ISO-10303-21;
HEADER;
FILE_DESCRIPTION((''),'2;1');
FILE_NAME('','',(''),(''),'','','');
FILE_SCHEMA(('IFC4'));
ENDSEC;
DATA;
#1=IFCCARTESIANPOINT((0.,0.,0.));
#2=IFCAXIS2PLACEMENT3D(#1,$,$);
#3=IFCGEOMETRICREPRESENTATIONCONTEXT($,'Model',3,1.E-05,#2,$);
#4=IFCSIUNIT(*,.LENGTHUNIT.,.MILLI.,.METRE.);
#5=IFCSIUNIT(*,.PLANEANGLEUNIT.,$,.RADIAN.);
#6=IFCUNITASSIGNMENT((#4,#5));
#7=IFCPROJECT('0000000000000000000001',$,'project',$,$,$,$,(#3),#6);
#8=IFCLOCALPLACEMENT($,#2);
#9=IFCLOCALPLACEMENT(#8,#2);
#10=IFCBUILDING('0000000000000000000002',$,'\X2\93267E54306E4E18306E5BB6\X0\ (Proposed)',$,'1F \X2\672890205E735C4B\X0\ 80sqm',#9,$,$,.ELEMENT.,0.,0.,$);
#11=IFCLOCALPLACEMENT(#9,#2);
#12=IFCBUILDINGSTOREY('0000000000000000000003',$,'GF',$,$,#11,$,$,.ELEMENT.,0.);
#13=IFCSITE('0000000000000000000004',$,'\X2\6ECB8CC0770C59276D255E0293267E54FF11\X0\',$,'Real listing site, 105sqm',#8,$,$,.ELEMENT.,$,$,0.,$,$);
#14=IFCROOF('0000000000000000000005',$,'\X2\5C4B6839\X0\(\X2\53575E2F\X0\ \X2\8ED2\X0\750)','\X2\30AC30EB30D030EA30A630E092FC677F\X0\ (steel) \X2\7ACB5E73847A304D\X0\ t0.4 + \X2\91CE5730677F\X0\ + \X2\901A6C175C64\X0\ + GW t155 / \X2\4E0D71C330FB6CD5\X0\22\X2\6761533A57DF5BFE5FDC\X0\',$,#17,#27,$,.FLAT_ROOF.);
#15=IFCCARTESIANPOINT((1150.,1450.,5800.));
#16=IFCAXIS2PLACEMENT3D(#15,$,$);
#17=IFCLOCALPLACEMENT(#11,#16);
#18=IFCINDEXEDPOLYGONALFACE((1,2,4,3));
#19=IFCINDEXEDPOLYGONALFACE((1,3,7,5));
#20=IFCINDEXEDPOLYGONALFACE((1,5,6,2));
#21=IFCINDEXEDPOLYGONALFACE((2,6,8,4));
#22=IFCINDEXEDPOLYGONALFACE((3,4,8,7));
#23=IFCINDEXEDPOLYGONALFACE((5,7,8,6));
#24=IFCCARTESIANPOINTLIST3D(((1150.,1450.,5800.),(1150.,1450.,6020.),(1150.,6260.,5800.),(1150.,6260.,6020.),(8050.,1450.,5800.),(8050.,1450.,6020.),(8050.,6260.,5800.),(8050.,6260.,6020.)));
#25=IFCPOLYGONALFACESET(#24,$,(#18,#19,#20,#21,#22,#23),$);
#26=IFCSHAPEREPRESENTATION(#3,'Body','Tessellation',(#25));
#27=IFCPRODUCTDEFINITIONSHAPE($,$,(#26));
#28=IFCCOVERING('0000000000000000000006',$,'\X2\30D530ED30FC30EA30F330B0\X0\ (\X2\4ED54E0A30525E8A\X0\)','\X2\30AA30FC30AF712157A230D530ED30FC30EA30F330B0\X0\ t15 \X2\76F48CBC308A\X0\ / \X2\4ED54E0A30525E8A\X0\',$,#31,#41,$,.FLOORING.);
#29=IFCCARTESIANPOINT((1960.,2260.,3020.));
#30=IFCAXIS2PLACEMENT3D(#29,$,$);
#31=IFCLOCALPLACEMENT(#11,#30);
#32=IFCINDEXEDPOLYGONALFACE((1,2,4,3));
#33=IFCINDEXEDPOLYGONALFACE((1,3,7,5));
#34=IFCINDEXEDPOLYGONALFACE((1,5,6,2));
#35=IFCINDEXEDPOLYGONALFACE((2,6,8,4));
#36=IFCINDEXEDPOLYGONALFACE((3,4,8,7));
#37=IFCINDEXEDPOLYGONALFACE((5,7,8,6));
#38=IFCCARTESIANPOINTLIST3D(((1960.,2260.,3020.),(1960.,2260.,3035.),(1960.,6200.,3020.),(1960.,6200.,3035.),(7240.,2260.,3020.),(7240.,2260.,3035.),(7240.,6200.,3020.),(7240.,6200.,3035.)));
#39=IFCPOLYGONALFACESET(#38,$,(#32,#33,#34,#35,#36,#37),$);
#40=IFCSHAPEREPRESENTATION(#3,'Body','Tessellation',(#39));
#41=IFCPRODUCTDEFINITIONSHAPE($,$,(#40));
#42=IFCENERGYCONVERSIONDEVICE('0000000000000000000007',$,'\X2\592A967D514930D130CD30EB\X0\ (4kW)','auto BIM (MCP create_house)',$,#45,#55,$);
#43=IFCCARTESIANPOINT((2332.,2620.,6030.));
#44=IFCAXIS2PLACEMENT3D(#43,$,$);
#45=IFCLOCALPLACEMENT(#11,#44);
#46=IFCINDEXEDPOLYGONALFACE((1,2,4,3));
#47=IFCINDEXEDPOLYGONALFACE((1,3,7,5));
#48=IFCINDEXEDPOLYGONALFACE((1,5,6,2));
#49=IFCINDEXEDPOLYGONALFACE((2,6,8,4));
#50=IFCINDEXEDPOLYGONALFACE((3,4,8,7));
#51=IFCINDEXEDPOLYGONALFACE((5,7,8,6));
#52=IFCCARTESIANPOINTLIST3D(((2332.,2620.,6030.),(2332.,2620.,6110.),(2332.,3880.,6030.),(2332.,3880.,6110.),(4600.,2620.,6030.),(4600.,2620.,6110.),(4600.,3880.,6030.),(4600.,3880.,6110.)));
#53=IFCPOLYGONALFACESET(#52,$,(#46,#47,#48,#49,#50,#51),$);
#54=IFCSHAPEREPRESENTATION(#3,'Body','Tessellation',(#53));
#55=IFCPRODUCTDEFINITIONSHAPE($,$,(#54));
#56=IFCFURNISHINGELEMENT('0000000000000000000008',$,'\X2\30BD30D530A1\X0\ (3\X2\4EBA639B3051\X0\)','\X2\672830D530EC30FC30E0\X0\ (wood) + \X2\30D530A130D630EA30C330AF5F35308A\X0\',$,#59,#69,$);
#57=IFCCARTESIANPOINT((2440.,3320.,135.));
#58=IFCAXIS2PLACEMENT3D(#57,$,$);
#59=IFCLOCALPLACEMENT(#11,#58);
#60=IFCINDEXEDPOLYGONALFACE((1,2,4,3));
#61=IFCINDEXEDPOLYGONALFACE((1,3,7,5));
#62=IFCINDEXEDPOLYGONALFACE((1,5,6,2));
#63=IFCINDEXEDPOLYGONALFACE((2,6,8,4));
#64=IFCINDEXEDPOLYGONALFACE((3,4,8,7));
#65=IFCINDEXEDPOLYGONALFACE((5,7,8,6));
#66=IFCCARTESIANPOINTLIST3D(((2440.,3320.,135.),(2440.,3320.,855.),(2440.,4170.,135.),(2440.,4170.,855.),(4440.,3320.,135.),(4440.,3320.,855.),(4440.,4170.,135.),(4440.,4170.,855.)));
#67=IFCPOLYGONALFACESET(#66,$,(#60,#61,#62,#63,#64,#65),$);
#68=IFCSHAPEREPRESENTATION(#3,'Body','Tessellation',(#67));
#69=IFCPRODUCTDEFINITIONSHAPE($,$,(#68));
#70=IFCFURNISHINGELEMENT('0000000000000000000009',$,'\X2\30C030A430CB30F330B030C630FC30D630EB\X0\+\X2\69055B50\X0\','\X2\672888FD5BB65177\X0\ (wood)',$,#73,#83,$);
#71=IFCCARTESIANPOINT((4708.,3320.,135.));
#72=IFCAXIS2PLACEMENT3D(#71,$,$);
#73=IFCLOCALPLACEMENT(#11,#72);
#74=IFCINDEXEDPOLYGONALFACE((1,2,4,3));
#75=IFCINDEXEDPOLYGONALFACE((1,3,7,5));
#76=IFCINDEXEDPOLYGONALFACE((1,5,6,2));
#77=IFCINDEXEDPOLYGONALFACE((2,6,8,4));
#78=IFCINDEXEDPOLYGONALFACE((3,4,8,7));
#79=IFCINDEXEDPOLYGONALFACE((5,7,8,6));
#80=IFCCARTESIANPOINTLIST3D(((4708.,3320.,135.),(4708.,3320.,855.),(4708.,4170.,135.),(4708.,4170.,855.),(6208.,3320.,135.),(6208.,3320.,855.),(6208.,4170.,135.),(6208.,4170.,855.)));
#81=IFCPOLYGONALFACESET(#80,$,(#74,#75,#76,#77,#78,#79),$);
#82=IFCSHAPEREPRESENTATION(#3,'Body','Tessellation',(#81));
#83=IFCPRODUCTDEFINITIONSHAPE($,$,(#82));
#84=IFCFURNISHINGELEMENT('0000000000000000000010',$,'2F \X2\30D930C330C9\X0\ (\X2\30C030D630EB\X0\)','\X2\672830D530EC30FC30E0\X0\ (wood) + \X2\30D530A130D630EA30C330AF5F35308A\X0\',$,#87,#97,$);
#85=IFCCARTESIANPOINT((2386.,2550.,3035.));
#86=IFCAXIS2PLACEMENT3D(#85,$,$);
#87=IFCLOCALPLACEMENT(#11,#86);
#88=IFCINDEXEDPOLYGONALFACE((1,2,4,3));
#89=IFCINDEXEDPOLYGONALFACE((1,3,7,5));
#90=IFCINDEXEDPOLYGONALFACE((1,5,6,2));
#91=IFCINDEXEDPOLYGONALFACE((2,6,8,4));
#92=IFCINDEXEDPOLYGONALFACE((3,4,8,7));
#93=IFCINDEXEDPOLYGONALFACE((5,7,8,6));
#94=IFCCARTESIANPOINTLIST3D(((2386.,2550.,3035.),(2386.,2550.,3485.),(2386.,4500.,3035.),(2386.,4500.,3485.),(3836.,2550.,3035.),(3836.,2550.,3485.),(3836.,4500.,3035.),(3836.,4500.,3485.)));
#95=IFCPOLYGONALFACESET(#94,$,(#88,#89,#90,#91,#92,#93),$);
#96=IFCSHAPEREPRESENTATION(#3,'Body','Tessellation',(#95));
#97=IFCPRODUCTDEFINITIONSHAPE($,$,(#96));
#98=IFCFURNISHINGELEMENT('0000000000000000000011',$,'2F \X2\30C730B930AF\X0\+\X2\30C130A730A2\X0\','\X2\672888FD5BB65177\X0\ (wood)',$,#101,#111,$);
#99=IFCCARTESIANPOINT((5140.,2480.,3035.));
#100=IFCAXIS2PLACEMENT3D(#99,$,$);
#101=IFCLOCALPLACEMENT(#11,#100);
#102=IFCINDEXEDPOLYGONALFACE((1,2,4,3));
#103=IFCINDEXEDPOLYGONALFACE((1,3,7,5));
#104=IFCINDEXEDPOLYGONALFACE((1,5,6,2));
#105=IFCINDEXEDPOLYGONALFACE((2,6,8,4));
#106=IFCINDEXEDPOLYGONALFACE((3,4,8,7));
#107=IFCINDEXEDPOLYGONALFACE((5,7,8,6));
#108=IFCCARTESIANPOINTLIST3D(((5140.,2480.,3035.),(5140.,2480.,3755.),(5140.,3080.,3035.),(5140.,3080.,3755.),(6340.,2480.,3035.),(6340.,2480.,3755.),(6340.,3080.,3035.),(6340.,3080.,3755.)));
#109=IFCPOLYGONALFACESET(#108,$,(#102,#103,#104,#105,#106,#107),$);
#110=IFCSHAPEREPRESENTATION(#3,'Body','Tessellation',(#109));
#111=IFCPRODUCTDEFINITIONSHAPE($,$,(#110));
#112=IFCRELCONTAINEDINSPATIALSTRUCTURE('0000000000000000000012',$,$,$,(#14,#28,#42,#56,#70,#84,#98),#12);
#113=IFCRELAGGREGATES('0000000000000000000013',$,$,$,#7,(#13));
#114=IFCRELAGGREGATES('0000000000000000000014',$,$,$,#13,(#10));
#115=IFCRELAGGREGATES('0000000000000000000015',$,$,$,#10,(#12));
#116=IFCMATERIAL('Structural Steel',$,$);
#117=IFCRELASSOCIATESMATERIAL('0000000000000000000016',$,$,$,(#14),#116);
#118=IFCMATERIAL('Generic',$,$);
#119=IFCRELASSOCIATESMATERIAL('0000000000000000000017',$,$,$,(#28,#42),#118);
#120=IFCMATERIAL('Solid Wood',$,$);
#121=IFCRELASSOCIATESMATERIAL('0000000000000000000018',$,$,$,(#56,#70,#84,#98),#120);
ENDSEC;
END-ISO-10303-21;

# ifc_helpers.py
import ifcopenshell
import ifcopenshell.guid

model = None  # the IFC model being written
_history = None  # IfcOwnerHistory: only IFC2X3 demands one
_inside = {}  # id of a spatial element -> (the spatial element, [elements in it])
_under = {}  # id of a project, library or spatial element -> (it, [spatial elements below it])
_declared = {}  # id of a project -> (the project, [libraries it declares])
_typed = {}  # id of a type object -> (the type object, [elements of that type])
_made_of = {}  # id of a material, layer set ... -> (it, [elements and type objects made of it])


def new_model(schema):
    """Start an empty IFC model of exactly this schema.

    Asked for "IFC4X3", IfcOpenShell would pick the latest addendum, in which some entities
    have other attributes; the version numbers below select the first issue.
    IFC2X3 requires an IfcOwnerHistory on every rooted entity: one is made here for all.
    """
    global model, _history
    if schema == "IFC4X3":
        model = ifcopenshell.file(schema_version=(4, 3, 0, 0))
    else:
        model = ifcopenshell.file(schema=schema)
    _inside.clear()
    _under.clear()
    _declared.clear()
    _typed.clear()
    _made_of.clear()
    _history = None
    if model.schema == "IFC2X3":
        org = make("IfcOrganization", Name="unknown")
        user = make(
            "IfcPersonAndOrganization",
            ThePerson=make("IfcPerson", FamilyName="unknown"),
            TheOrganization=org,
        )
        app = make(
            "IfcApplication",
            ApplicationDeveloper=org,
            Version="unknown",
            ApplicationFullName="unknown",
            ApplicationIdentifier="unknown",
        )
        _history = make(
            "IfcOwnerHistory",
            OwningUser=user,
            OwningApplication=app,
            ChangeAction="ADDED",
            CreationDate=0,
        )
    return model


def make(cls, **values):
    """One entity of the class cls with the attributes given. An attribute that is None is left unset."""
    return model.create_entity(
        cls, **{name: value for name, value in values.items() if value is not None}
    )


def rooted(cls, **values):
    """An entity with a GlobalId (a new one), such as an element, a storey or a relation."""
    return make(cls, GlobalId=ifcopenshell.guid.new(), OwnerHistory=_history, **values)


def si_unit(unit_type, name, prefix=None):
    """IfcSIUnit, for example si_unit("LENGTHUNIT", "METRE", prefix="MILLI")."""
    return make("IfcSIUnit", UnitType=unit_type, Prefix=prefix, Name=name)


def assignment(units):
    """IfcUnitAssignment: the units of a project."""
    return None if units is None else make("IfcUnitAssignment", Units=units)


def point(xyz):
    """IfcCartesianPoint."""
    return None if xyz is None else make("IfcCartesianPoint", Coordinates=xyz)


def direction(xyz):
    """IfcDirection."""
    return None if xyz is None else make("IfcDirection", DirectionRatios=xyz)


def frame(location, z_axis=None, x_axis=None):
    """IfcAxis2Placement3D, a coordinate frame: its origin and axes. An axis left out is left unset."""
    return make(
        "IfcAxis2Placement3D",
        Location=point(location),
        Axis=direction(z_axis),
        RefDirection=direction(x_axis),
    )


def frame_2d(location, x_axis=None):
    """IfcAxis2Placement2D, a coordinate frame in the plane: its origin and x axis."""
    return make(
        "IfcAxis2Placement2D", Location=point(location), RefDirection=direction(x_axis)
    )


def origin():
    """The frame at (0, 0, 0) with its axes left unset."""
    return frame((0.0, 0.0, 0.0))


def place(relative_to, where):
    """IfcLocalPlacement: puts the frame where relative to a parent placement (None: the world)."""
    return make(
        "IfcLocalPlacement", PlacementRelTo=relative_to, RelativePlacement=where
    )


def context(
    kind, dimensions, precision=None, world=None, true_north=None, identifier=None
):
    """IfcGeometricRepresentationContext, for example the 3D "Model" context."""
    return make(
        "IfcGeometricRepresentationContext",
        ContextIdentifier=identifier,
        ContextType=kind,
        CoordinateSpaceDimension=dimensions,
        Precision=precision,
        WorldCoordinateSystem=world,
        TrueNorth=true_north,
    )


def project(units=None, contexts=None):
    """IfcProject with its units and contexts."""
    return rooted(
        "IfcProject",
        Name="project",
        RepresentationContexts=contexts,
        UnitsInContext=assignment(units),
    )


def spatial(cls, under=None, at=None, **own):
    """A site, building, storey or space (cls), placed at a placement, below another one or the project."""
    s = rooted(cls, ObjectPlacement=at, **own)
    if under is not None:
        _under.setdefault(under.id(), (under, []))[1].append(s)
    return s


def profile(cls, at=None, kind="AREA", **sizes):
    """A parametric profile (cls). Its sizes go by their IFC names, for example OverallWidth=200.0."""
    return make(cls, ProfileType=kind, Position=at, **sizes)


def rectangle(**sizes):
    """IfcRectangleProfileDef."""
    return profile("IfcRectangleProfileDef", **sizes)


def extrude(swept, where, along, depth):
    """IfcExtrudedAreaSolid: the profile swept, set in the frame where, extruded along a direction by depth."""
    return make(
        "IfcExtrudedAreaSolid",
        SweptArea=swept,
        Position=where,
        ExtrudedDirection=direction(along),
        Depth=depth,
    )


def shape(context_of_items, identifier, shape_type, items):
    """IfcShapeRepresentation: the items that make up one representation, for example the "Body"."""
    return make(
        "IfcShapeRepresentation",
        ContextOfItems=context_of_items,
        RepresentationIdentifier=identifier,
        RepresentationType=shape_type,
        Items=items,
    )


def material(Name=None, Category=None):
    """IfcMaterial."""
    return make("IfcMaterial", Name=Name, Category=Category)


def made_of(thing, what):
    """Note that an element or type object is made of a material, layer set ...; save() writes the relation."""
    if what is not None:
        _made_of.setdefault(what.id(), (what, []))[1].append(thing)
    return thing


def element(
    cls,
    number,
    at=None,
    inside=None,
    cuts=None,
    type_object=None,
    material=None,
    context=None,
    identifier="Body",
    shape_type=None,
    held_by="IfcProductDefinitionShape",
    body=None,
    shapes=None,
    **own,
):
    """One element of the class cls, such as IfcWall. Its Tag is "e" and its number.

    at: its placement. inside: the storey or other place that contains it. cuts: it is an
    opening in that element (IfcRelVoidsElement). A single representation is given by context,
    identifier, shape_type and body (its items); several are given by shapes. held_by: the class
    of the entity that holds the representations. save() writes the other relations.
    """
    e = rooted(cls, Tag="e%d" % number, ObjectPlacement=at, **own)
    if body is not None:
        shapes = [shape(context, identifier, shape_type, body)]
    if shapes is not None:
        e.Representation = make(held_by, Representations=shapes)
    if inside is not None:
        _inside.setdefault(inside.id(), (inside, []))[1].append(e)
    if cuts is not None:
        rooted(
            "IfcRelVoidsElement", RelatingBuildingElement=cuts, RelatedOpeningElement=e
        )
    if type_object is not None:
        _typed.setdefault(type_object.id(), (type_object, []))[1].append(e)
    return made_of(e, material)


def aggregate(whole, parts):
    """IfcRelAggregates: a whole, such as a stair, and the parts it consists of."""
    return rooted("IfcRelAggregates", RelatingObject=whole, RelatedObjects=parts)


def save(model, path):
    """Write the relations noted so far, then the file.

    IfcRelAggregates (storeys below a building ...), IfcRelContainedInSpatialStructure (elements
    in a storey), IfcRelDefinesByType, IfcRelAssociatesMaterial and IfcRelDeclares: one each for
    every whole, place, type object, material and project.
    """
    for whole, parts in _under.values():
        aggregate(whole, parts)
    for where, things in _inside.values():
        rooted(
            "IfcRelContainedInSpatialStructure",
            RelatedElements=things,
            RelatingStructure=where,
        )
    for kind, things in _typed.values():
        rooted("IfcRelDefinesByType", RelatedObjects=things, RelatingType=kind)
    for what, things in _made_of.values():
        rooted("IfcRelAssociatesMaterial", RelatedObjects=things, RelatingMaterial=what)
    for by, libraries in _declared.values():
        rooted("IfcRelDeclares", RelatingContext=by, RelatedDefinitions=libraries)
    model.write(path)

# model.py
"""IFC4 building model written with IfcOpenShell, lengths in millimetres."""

from ifc_helpers import new_model, si_unit, frame, frame_2d, origin, place, context, project, spatial, rectangle, extrude, material, element, save


model = new_model("IFC4")

# Units and contexts
model_context = context("Model", 3, precision=1e-05, world=origin())
ifc_project = project(units=[si_unit("LENGTHUNIT", "METRE", prefix="MILLI"), si_unit("PLANEANGLEUNIT", "RADIAN")], contexts=[model_context])

# Site, building, storey
site_placement = place(None, origin())
site = spatial("IfcSite", under=ifc_project, at=site_placement, Name="滋賀県大津市錦織１", ObjectType="Real listing site, 105sqm", CompositionType="ELEMENT", RefElevation=0.0)
building_placement = place(site_placement, origin())
building = spatial("IfcBuilding", under=site, at=building_placement, Name="錦織の丘の家 (Proposed)", ObjectType="1F 木造平屋 80sqm", CompositionType="ELEMENT", ElevationOfRefHeight=0.0, ElevationOfTerrain=0.0)
storey_placement = place(building_placement, origin())
storey = spatial("IfcBuildingStorey", under=building, at=storey_placement, Name="GF", CompositionType="ELEMENT", Elevation=0.0)

# Shared definitions
ifc_material_1 = material(Name="Solid Wood")

# Shared definitions
ifc_material_2 = material(Name="Generic")

# Roof
ifc_material_3 = material(Name="Structural Steel")
for number, where, name in (
    (1, (1150.0, 1450.0, 5800.0), "屋根(南帯 軒750)"),
):
    element("IfcRoof", number, at=place(storey_placement, frame(where)), inside=storey, material=ifc_material_3, Name=name, Description="ガルバリウム鋼板 (steel) 立平葺き t0.4 + 野地板 + 通気層 + GW t155 / 不燃・法22条区域対応", PredefinedType="FLAT_ROOF", context=model_context, shape_type="SweptSolid", body=[
        extrude(rectangle(XDim=6900.0, YDim=4810.0, at=frame_2d((3450.0, 2405.0))), frame((1150.0, 1450.0, 5800.0)), (0.0, 0.0, 1.0), 220.0),
    ])

# Covering
covering_placement = place(storey_placement, frame((1960.0, 2260.0, 3020.0)))
element("IfcCovering", 2, at=covering_placement, inside=storey, material=ifc_material_2, Name="フローリング (仕上げ床)", Description="オーク無垢フローリング t15 直貼り / 仕上げ床", PredefinedType="FLOORING", context=model_context, shape_type="SweptSolid", body=[
    extrude(rectangle(XDim=5280.0, YDim=3940.0, at=frame_2d((2640.0, 1970.0))), frame((1960.0, 2260.0, 3020.0)), (0.0, 0.0, 1.0), 15.0),
])

# Energy conversion device
energy_conversion_device_placement = place(storey_placement, frame((2332.0, 2620.0, 6030.0)))
element("IfcEnergyConversionDevice", 3, at=energy_conversion_device_placement, inside=storey, material=ifc_material_2, Name="太陽光パネル (4kW)", Description="auto BIM (MCP create_house)", context=model_context, shape_type="SweptSolid", body=[
    extrude(rectangle(XDim=2268.0, YDim=1260.0, at=frame_2d((1134.0, 630.0))), frame((2332.0, 2620.0, 6030.0)), (0.0, 0.0, 1.0), 80.0),
])

# Furnishing elements
furnishing_1_placement = place(storey_placement, frame((2440.0, 3320.0, 135.0)))
element("IfcFurnishingElement", 4, at=furnishing_1_placement, inside=storey, material=ifc_material_1, Name="ソファ (3人掛け)", Description="木フレーム (wood) + ファブリック張り", context=model_context, shape_type="SweptSolid", body=[
    extrude(rectangle(XDim=2000.0, YDim=850.0, at=frame_2d((1000.0, 425.0))), frame((2440.0, 3320.0, 135.0)), (0.0, 0.0, 1.0), 720.0),
])
furnishing_2_placement = place(storey_placement, frame((4708.0, 3320.0, 135.0)))
element("IfcFurnishingElement", 5, at=furnishing_2_placement, inside=storey, material=ifc_material_1, Name="ダイニングテーブル+椅子", Description="木製家具 (wood)", context=model_context, shape_type="SweptSolid", body=[
    extrude(rectangle(XDim=1500.0, YDim=850.0, at=frame_2d((750.0, 425.0))), frame((4708.0, 3320.0, 135.0)), (0.0, 0.0, 1.0), 720.0),
])
furnishing_3_placement = place(storey_placement, frame((2386.0, 2550.0, 3035.0)))
element("IfcFurnishingElement", 6, at=furnishing_3_placement, inside=storey, material=ifc_material_1, Name="2F ベッド (ダブル)", Description="木フレーム (wood) + ファブリック張り", context=model_context, shape_type="SweptSolid", body=[
    extrude(rectangle(XDim=1450.0, YDim=1950.0, at=frame_2d((725.0, 975.0))), frame((2386.0, 2550.0, 3035.0)), (0.0, 0.0, 1.0), 450.0),
])
furnishing_4_placement = place(storey_placement, frame((5140.0, 2480.0, 3035.0)))
element("IfcFurnishingElement", 7, at=furnishing_4_placement, inside=storey, material=ifc_material_1, Name="2F デスク+チェア", Description="木製家具 (wood)", context=model_context, shape_type="SweptSolid", body=[
    extrude(rectangle(XDim=1200.0, YDim=600.0, at=frame_2d((600.0, 300.0))), frame((5140.0, 2480.0, 3035.0)), (0.0, 0.0, 1.0), 720.0),
])

save(model, "model.ifc")
